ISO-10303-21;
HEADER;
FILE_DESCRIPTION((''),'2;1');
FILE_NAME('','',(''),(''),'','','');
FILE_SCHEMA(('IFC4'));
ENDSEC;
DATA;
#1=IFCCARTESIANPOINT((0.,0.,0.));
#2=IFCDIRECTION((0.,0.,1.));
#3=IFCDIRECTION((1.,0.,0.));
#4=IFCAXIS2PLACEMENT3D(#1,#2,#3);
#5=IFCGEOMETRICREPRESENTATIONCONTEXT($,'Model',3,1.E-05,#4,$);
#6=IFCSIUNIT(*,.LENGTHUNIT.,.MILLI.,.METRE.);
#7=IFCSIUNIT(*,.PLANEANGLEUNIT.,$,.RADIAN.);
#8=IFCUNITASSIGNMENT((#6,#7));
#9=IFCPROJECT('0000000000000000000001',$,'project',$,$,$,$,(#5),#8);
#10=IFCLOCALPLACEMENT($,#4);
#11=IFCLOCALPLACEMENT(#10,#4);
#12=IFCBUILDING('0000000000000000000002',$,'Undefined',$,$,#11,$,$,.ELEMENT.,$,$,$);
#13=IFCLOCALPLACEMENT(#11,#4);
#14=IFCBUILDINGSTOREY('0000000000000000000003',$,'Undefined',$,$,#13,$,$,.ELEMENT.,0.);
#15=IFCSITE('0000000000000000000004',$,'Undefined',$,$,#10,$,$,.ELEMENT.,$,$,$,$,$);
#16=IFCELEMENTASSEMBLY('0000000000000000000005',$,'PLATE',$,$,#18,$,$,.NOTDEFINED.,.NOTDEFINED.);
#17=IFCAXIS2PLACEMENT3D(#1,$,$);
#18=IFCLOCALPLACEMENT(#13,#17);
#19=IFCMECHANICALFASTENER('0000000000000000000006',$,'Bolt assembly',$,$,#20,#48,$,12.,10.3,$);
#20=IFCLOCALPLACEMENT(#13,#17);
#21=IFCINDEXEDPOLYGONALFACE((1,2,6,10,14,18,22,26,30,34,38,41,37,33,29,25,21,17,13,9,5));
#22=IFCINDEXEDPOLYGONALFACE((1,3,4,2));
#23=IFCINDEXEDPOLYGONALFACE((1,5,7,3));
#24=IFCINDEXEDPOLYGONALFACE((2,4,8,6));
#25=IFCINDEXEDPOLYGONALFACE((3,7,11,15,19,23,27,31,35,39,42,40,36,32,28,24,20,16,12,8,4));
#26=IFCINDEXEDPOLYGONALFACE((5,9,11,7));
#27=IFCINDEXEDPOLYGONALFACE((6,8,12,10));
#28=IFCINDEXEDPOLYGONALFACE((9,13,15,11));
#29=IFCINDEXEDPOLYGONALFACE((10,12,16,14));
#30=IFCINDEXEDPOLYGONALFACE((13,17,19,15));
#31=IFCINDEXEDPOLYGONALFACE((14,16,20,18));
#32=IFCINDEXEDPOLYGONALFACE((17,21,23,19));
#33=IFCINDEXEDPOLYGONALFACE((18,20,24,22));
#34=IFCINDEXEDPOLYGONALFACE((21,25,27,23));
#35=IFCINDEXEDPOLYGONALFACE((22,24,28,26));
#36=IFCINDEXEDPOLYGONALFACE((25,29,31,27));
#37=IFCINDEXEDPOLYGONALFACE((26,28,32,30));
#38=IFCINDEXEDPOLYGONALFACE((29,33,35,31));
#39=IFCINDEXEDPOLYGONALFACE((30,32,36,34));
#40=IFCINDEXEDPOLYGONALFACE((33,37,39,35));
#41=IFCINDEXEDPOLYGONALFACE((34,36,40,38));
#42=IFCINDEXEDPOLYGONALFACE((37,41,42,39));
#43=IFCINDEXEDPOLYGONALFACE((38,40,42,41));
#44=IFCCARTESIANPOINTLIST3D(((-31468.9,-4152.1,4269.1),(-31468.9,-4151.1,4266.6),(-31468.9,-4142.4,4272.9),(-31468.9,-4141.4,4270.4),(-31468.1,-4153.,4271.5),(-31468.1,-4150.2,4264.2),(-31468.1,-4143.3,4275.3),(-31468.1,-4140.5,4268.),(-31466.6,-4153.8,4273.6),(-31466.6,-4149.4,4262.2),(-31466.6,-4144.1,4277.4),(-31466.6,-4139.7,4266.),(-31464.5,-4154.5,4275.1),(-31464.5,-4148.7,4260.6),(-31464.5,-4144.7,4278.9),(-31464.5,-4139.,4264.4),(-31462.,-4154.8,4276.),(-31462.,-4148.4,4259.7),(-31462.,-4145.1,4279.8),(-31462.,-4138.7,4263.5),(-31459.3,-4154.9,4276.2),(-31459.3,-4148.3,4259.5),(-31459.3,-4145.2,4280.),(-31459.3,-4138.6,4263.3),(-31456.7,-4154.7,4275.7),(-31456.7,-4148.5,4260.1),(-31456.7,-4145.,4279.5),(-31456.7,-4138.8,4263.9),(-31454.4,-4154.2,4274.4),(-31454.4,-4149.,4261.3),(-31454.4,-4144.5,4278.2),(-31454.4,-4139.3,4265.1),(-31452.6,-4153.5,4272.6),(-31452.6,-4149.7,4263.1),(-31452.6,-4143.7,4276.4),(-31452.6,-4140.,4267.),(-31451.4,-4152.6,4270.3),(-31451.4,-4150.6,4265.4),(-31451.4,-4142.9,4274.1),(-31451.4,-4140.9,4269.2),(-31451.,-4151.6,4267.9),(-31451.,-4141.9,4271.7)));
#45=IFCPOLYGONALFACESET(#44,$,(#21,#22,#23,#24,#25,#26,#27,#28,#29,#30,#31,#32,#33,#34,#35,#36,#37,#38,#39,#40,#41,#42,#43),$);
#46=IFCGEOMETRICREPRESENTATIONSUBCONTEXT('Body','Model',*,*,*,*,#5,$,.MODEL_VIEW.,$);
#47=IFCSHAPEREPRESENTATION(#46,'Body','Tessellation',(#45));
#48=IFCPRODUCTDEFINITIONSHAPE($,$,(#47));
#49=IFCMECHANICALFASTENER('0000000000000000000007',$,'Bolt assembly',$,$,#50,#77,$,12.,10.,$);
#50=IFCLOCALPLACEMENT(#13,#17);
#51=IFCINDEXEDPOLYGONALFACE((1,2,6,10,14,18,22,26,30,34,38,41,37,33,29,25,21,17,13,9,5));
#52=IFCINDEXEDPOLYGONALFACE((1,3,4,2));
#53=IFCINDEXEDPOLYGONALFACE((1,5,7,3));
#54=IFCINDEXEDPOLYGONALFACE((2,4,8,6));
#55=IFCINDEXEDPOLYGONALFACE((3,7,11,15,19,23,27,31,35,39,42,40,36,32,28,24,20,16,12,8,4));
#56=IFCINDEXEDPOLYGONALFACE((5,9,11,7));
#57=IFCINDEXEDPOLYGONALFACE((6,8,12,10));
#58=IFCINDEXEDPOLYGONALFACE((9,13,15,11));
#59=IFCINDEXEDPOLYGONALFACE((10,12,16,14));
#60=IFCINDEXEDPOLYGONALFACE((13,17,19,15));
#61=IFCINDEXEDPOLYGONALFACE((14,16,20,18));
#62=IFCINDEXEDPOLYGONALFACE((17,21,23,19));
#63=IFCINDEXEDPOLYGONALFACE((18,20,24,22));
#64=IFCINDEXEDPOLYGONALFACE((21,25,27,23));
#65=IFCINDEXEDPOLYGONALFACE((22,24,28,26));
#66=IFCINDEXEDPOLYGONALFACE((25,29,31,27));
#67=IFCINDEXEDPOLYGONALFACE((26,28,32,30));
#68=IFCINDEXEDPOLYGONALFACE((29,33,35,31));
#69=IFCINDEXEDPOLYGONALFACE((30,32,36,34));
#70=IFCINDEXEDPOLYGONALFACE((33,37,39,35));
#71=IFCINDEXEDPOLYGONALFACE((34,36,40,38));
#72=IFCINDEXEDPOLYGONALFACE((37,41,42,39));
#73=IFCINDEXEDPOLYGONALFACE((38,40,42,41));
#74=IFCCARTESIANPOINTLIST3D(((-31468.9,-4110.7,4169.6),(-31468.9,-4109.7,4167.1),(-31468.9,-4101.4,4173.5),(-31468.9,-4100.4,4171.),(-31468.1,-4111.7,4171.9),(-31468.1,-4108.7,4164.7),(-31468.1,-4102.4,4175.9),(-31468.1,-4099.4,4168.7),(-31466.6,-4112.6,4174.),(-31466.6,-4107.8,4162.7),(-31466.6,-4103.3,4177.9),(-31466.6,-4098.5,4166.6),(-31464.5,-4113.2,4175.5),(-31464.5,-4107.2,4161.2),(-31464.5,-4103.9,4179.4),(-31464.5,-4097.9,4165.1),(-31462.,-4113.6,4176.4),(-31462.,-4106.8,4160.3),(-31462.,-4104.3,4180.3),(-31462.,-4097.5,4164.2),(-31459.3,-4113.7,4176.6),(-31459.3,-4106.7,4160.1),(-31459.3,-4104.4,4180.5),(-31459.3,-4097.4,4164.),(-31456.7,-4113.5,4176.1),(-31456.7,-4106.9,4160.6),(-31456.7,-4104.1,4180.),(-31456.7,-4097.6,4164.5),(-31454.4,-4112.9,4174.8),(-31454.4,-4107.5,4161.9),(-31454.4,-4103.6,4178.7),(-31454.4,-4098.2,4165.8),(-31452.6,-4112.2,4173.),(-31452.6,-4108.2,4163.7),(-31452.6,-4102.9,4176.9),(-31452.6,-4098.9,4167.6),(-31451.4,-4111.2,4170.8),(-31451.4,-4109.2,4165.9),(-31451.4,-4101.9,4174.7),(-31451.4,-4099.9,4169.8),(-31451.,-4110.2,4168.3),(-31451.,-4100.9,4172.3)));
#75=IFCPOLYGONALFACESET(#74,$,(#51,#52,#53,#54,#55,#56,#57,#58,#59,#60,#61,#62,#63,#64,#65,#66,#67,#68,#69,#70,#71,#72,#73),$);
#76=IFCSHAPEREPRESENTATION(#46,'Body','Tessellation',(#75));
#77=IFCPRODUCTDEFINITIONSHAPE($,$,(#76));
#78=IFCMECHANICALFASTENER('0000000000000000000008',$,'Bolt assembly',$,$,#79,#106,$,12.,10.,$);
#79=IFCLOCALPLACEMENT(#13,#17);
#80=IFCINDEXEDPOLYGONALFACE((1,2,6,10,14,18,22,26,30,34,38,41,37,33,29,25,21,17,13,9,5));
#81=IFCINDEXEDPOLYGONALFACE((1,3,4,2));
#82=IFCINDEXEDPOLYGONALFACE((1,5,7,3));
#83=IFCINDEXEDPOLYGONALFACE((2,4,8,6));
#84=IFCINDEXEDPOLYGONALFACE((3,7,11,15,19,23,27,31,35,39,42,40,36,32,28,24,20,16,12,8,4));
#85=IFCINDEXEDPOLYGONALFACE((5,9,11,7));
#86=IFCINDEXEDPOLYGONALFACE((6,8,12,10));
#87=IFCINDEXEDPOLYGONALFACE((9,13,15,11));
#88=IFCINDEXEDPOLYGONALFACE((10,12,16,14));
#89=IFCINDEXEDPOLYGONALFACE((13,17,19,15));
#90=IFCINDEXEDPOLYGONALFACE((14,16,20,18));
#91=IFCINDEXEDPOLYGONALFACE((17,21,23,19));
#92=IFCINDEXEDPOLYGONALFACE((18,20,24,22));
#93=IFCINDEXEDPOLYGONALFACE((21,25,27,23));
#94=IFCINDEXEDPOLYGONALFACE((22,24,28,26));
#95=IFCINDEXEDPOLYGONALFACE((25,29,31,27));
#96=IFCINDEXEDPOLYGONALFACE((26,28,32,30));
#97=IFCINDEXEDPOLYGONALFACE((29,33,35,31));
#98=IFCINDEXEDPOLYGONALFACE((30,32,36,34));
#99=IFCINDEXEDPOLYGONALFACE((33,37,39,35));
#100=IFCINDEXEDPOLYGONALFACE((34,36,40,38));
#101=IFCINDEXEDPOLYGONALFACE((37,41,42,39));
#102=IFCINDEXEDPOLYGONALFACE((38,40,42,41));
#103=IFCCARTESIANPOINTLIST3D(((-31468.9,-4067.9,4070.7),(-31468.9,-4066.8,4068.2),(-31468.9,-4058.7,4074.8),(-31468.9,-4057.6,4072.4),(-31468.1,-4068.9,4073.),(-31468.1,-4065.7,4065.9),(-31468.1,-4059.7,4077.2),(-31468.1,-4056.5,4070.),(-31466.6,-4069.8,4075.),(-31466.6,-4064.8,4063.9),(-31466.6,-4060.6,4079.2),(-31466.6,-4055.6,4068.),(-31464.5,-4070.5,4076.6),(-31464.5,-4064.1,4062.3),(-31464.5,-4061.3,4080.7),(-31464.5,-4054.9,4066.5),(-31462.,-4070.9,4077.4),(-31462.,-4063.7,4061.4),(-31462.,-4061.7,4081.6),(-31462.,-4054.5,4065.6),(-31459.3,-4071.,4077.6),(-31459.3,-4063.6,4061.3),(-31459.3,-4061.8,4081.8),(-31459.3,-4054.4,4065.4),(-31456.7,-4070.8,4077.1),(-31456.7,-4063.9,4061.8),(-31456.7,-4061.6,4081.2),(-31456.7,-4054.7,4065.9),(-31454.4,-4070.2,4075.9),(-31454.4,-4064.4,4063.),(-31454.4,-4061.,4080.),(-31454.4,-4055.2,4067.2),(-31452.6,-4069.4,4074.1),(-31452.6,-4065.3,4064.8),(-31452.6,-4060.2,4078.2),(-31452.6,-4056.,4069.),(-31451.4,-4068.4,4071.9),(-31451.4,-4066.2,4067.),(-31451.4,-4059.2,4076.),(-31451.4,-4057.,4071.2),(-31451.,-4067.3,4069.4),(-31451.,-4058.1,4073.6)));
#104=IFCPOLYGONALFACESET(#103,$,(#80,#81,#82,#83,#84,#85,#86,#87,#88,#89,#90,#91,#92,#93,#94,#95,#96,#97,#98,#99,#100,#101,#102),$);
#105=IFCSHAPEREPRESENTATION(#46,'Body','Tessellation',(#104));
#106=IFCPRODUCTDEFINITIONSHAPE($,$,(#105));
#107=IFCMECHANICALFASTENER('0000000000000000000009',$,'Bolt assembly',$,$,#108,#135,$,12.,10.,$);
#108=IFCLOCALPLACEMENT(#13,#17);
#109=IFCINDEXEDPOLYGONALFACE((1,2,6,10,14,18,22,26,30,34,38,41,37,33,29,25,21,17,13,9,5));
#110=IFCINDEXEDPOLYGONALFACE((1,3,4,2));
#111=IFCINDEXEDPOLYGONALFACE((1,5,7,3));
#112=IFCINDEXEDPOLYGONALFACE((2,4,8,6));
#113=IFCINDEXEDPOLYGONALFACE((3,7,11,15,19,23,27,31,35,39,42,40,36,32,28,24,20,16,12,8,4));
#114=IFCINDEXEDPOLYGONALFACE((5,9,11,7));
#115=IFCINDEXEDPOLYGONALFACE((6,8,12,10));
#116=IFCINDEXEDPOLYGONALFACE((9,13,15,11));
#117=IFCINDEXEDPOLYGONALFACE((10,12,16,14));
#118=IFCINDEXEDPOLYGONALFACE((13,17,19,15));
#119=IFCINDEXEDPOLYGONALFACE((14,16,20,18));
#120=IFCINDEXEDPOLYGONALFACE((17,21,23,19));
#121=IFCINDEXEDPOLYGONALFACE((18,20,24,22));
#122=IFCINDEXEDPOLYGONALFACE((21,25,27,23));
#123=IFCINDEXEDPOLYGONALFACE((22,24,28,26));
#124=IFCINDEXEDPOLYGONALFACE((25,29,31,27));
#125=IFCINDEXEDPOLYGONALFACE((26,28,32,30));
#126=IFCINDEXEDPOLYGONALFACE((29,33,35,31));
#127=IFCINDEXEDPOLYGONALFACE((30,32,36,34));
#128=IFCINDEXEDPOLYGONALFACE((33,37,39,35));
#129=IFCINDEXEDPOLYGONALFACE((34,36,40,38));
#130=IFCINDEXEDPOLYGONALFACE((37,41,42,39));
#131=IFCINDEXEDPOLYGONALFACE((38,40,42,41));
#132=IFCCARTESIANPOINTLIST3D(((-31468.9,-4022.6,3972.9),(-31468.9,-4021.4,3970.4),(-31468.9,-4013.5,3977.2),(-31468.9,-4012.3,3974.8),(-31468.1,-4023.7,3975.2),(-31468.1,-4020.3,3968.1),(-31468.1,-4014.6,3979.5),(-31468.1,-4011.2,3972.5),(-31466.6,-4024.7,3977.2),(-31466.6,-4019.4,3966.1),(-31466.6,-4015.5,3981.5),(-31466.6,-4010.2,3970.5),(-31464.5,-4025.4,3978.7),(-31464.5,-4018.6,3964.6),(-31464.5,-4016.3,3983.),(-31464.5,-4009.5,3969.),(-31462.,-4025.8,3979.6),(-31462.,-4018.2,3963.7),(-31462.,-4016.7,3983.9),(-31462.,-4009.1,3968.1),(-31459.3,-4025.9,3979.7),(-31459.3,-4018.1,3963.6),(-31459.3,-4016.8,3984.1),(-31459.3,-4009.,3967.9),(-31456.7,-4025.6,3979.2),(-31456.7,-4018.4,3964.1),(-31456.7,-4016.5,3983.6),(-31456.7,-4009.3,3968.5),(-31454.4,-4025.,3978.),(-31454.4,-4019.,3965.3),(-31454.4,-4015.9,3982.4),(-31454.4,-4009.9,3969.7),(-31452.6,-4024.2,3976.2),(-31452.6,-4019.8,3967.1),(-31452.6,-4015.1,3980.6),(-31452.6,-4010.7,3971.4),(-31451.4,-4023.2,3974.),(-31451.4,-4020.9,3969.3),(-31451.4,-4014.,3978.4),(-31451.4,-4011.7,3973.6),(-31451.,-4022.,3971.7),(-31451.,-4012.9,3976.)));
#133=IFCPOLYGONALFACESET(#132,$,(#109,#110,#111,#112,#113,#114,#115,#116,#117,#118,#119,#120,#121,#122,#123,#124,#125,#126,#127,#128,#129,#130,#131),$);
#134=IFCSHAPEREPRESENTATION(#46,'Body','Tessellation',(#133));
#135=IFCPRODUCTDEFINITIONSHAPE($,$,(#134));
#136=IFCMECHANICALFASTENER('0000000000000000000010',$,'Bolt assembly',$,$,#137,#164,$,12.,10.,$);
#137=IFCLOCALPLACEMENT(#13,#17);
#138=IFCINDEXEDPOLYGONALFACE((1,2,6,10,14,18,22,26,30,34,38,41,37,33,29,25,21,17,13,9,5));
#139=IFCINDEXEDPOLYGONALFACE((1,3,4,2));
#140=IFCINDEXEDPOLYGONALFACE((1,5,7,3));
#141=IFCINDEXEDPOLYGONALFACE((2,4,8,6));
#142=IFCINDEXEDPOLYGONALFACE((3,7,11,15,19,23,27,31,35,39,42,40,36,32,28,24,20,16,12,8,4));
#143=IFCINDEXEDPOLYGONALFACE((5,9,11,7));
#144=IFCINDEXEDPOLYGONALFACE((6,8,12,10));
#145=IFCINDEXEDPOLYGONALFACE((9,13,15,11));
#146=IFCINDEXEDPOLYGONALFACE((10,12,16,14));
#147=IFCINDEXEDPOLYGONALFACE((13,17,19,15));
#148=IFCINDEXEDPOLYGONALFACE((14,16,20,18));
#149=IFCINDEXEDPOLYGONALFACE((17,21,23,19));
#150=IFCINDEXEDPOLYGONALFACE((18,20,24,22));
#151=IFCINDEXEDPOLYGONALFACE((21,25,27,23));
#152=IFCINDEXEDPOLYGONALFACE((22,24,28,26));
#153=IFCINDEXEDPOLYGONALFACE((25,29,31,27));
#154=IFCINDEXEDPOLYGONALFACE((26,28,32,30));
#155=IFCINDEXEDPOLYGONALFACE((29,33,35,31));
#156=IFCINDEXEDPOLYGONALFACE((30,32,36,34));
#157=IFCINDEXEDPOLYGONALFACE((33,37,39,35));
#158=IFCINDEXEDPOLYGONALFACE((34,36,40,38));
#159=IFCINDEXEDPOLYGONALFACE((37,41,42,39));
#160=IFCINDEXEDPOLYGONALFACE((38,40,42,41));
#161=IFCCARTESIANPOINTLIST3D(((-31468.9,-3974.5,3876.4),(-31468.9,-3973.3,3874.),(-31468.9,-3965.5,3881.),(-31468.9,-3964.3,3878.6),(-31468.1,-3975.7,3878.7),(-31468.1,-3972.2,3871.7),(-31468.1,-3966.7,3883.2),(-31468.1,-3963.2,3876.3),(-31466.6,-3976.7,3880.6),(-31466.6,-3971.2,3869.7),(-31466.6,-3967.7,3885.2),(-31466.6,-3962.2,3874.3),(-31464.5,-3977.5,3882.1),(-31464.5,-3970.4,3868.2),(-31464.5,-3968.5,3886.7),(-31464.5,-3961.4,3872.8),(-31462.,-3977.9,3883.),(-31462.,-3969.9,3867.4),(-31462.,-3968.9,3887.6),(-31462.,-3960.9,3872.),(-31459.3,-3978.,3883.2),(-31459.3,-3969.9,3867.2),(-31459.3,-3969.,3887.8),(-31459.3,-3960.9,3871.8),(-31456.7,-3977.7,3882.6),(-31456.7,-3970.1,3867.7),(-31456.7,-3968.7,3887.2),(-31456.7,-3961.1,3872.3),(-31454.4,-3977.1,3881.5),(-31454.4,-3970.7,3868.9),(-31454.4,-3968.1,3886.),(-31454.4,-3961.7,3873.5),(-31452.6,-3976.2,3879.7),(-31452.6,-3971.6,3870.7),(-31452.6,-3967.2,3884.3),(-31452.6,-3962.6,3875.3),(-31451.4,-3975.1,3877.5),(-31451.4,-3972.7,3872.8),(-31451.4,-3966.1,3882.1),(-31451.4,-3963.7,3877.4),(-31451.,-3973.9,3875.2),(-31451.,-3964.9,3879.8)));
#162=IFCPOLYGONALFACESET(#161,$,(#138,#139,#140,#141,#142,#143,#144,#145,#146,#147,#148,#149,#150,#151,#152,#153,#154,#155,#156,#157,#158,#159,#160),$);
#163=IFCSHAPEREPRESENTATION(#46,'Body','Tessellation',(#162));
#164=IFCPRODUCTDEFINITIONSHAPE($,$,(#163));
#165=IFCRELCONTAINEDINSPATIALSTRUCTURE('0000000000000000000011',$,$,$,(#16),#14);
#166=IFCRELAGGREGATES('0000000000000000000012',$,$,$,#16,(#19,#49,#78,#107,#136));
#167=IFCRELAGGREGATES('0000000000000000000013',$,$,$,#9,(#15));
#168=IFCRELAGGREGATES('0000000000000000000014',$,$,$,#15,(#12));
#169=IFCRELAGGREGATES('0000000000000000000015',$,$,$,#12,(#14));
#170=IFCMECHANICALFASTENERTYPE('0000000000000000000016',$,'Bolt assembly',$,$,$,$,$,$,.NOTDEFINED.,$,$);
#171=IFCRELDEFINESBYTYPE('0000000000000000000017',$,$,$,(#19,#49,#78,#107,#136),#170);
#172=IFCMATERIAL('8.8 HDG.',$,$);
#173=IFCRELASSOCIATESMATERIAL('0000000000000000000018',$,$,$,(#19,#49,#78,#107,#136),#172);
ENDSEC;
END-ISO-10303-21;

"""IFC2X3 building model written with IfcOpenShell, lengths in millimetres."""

from ifc_helpers import new_model, si_unit, frame, origin_with_axes, origin_2d_with_axis, place, context, subcontext, project, spatial, circle, extrude, source, transform, mapped, material, type_object, element, aggregate, save


model = new_model("IFC2X3")

# Units and contexts
model_context = context("Model", 3, precision=1e-05, world=origin_with_axes())
body_context = subcontext(model_context, "Body", "Model", "MODEL_VIEW")
ifc_project = project(units=[si_unit("LENGTHUNIT", "METRE", prefix="MILLI"), si_unit("PLANEANGLEUNIT", "RADIAN")], contexts=[model_context])

# Site, building, storey
site_placement = place(None, origin_with_axes())
site = spatial("IfcSite", under=ifc_project, at=site_placement, Name="Undefined", CompositionType="ELEMENT")
building_placement = place(site_placement, origin_with_axes())
building = spatial("IfcBuilding", under=site, at=building_placement, Name="Undefined", CompositionType="ELEMENT")
storey_placement = place(building_placement, origin_with_axes())
storey = spatial("IfcBuildingStorey", under=building, at=storey_placement, Name="Undefined", CompositionType="ELEMENT", Elevation=0.0)

# Element assembly
assembly_1_placement = place(storey_placement, origin_with_axes())
assembly_1 = element("IfcElementAssembly", 1, at=assembly_1_placement, inside=storey, Name="PLATE", AssemblyPlace="NOTDEFINED", PredefinedType="NOTDEFINED")

# Shared definitions
mechanical_fastener_type = type_object("IfcMechanicalFastenerType", Name="Bolt assembly")

# Mechanical fasteners
ifc_material_1 = material(Name="8.8 HDG.")
shared_shape_1 = source(origin_with_axes(), body_context, "Body", "SweptSolid", [
    extrude(circle(Radius=9.0, at=origin_2d_with_axis()), frame((0.0, 0.0, 0.0), z_axis=(0.0, 1.0, 0.0), x_axis=(1.0, 0.0, 0.0)), (0.0, 0.0, 1.0), 10.4),
])
mechanical_fastener_1_placement = place(assembly_1_placement, frame((-31460.0, -4151.6, 4267.8), z_axis=(0.000001, -0.365877, 0.930663), x_axis=(1.0, 0.0, -0.000001)))
mechanical_fastener_1 = element("IfcMechanicalFastener", 2, at=mechanical_fastener_1_placement, type_object=mechanical_fastener_type, material=ifc_material_1, Name="Bolt assembly", NominalDiameter=12.0, NominalLength=10.3, context=body_context, shape_type="MappedRepresentation", body=[
    mapped(shared_shape_1, transform((0.0, 0.0, 0.0))),
])
shared_shape_2 = source(origin_with_axes(), body_context, "Body", "SweptSolid", [
    extrude(circle(Radius=9.0, at=origin_2d_with_axis()), frame((0.0, 0.9, 0.0), z_axis=(0.0, 1.0, 0.0), x_axis=(1.0, 0.0, 0.0)), (0.0, 0.0, 1.0), 10.1),
])
mechanical_fastener_2_placement = place(assembly_1_placement, frame((-31460.0, -4111.0, 4168.0), z_axis=(0.000001, -0.388258, 0.921551), x_axis=(1.0, 0.0, -0.000001)))
mechanical_fastener_2 = element("IfcMechanicalFastener", 3, at=mechanical_fastener_2_placement, type_object=mechanical_fastener_type, material=ifc_material_1, Name="Bolt assembly", NominalDiameter=12.0, NominalLength=10.0, context=body_context, shape_type="MappedRepresentation", body=[
    mapped(shared_shape_2, transform((0.0, 0.0, 0.0))),
])
shared_shape_3 = source(origin_with_axes(), body_context, "Body", "SweptSolid", [
    extrude(circle(Radius=9.0, at=origin_2d_with_axis()), frame((0.0, 0.7, 0.0), z_axis=(0.0, 1.0, 0.0), x_axis=(1.0, 0.0, 0.0)), (0.0, 0.0, 1.0), 10.1),
])
mechanical_fastener_3_placement = place(assembly_1_placement, frame((-31460.0, -4067.9, 4069.2), z_axis=(0.000001, -0.410413, 0.9119), x_axis=(1.0, 0.0, -0.000001)))
mechanical_fastener_3 = element("IfcMechanicalFastener", 4, at=mechanical_fastener_3_placement, type_object=mechanical_fastener_type, material=ifc_material_1, Name="Bolt assembly", NominalDiameter=12.0, NominalLength=10.0, context=body_context, shape_type="MappedRepresentation", body=[
    mapped(shared_shape_3, transform((0.0, 0.0, 0.0))),
])
shared_shape_4 = source(origin_with_axes(), body_context, "Body", "SweptSolid", [
    extrude(circle(Radius=9.0, at=origin_2d_with_axis()), frame((0.0, 0.6, 0.0), z_axis=(0.0, 1.0, 0.0), x_axis=(1.0, 0.0, 0.0)), (0.0, 0.0, 1.0), 10.1),
])
mechanical_fastener_4_placement = place(assembly_1_placement, frame((-31460.0, -4022.5, 3971.4), z_axis=(0.000001, -0.432328, 0.901716), x_axis=(1.0, 0.0, -0.000001)))
mechanical_fastener_4 = element("IfcMechanicalFastener", 5, at=mechanical_fastener_4_placement, type_object=mechanical_fastener_type, material=ifc_material_1, Name="Bolt assembly", NominalDiameter=12.0, NominalLength=10.0, context=body_context, shape_type="MappedRepresentation", body=[
    mapped(shared_shape_4, transform((0.0, 0.0, 0.0))),
])
shared_shape_5 = source(origin_with_axes(), body_context, "Body", "SweptSolid", [
    extrude(circle(Radius=9.0, at=origin_2d_with_axis()), frame((0.0, 0.9, 0.0), z_axis=(0.0, 1.0, 0.0), x_axis=(1.0, 0.0, 0.0)), (0.0, 0.0, 1.0), 10.1),
])
mechanical_fastener_5_placement = place(assembly_1_placement, frame((-31460.0, -3974.7, 3874.8), z_axis=(0.000001, -0.453991, 0.891006), x_axis=(1.0, 0.0, -0.000001)))
mechanical_fastener_5 = element("IfcMechanicalFastener", 6, at=mechanical_fastener_5_placement, type_object=mechanical_fastener_type, material=ifc_material_1, Name="Bolt assembly", NominalDiameter=12.0, NominalLength=10.0, context=body_context, shape_type="MappedRepresentation", body=[
    mapped(shared_shape_5, transform((0.0, 0.0, 0.0))),
])
aggregate(assembly_1, [mechanical_fastener_1, mechanical_fastener_2, mechanical_fastener_3, mechanical_fastener_4, mechanical_fastener_5])

save(model, "model.ifc")
